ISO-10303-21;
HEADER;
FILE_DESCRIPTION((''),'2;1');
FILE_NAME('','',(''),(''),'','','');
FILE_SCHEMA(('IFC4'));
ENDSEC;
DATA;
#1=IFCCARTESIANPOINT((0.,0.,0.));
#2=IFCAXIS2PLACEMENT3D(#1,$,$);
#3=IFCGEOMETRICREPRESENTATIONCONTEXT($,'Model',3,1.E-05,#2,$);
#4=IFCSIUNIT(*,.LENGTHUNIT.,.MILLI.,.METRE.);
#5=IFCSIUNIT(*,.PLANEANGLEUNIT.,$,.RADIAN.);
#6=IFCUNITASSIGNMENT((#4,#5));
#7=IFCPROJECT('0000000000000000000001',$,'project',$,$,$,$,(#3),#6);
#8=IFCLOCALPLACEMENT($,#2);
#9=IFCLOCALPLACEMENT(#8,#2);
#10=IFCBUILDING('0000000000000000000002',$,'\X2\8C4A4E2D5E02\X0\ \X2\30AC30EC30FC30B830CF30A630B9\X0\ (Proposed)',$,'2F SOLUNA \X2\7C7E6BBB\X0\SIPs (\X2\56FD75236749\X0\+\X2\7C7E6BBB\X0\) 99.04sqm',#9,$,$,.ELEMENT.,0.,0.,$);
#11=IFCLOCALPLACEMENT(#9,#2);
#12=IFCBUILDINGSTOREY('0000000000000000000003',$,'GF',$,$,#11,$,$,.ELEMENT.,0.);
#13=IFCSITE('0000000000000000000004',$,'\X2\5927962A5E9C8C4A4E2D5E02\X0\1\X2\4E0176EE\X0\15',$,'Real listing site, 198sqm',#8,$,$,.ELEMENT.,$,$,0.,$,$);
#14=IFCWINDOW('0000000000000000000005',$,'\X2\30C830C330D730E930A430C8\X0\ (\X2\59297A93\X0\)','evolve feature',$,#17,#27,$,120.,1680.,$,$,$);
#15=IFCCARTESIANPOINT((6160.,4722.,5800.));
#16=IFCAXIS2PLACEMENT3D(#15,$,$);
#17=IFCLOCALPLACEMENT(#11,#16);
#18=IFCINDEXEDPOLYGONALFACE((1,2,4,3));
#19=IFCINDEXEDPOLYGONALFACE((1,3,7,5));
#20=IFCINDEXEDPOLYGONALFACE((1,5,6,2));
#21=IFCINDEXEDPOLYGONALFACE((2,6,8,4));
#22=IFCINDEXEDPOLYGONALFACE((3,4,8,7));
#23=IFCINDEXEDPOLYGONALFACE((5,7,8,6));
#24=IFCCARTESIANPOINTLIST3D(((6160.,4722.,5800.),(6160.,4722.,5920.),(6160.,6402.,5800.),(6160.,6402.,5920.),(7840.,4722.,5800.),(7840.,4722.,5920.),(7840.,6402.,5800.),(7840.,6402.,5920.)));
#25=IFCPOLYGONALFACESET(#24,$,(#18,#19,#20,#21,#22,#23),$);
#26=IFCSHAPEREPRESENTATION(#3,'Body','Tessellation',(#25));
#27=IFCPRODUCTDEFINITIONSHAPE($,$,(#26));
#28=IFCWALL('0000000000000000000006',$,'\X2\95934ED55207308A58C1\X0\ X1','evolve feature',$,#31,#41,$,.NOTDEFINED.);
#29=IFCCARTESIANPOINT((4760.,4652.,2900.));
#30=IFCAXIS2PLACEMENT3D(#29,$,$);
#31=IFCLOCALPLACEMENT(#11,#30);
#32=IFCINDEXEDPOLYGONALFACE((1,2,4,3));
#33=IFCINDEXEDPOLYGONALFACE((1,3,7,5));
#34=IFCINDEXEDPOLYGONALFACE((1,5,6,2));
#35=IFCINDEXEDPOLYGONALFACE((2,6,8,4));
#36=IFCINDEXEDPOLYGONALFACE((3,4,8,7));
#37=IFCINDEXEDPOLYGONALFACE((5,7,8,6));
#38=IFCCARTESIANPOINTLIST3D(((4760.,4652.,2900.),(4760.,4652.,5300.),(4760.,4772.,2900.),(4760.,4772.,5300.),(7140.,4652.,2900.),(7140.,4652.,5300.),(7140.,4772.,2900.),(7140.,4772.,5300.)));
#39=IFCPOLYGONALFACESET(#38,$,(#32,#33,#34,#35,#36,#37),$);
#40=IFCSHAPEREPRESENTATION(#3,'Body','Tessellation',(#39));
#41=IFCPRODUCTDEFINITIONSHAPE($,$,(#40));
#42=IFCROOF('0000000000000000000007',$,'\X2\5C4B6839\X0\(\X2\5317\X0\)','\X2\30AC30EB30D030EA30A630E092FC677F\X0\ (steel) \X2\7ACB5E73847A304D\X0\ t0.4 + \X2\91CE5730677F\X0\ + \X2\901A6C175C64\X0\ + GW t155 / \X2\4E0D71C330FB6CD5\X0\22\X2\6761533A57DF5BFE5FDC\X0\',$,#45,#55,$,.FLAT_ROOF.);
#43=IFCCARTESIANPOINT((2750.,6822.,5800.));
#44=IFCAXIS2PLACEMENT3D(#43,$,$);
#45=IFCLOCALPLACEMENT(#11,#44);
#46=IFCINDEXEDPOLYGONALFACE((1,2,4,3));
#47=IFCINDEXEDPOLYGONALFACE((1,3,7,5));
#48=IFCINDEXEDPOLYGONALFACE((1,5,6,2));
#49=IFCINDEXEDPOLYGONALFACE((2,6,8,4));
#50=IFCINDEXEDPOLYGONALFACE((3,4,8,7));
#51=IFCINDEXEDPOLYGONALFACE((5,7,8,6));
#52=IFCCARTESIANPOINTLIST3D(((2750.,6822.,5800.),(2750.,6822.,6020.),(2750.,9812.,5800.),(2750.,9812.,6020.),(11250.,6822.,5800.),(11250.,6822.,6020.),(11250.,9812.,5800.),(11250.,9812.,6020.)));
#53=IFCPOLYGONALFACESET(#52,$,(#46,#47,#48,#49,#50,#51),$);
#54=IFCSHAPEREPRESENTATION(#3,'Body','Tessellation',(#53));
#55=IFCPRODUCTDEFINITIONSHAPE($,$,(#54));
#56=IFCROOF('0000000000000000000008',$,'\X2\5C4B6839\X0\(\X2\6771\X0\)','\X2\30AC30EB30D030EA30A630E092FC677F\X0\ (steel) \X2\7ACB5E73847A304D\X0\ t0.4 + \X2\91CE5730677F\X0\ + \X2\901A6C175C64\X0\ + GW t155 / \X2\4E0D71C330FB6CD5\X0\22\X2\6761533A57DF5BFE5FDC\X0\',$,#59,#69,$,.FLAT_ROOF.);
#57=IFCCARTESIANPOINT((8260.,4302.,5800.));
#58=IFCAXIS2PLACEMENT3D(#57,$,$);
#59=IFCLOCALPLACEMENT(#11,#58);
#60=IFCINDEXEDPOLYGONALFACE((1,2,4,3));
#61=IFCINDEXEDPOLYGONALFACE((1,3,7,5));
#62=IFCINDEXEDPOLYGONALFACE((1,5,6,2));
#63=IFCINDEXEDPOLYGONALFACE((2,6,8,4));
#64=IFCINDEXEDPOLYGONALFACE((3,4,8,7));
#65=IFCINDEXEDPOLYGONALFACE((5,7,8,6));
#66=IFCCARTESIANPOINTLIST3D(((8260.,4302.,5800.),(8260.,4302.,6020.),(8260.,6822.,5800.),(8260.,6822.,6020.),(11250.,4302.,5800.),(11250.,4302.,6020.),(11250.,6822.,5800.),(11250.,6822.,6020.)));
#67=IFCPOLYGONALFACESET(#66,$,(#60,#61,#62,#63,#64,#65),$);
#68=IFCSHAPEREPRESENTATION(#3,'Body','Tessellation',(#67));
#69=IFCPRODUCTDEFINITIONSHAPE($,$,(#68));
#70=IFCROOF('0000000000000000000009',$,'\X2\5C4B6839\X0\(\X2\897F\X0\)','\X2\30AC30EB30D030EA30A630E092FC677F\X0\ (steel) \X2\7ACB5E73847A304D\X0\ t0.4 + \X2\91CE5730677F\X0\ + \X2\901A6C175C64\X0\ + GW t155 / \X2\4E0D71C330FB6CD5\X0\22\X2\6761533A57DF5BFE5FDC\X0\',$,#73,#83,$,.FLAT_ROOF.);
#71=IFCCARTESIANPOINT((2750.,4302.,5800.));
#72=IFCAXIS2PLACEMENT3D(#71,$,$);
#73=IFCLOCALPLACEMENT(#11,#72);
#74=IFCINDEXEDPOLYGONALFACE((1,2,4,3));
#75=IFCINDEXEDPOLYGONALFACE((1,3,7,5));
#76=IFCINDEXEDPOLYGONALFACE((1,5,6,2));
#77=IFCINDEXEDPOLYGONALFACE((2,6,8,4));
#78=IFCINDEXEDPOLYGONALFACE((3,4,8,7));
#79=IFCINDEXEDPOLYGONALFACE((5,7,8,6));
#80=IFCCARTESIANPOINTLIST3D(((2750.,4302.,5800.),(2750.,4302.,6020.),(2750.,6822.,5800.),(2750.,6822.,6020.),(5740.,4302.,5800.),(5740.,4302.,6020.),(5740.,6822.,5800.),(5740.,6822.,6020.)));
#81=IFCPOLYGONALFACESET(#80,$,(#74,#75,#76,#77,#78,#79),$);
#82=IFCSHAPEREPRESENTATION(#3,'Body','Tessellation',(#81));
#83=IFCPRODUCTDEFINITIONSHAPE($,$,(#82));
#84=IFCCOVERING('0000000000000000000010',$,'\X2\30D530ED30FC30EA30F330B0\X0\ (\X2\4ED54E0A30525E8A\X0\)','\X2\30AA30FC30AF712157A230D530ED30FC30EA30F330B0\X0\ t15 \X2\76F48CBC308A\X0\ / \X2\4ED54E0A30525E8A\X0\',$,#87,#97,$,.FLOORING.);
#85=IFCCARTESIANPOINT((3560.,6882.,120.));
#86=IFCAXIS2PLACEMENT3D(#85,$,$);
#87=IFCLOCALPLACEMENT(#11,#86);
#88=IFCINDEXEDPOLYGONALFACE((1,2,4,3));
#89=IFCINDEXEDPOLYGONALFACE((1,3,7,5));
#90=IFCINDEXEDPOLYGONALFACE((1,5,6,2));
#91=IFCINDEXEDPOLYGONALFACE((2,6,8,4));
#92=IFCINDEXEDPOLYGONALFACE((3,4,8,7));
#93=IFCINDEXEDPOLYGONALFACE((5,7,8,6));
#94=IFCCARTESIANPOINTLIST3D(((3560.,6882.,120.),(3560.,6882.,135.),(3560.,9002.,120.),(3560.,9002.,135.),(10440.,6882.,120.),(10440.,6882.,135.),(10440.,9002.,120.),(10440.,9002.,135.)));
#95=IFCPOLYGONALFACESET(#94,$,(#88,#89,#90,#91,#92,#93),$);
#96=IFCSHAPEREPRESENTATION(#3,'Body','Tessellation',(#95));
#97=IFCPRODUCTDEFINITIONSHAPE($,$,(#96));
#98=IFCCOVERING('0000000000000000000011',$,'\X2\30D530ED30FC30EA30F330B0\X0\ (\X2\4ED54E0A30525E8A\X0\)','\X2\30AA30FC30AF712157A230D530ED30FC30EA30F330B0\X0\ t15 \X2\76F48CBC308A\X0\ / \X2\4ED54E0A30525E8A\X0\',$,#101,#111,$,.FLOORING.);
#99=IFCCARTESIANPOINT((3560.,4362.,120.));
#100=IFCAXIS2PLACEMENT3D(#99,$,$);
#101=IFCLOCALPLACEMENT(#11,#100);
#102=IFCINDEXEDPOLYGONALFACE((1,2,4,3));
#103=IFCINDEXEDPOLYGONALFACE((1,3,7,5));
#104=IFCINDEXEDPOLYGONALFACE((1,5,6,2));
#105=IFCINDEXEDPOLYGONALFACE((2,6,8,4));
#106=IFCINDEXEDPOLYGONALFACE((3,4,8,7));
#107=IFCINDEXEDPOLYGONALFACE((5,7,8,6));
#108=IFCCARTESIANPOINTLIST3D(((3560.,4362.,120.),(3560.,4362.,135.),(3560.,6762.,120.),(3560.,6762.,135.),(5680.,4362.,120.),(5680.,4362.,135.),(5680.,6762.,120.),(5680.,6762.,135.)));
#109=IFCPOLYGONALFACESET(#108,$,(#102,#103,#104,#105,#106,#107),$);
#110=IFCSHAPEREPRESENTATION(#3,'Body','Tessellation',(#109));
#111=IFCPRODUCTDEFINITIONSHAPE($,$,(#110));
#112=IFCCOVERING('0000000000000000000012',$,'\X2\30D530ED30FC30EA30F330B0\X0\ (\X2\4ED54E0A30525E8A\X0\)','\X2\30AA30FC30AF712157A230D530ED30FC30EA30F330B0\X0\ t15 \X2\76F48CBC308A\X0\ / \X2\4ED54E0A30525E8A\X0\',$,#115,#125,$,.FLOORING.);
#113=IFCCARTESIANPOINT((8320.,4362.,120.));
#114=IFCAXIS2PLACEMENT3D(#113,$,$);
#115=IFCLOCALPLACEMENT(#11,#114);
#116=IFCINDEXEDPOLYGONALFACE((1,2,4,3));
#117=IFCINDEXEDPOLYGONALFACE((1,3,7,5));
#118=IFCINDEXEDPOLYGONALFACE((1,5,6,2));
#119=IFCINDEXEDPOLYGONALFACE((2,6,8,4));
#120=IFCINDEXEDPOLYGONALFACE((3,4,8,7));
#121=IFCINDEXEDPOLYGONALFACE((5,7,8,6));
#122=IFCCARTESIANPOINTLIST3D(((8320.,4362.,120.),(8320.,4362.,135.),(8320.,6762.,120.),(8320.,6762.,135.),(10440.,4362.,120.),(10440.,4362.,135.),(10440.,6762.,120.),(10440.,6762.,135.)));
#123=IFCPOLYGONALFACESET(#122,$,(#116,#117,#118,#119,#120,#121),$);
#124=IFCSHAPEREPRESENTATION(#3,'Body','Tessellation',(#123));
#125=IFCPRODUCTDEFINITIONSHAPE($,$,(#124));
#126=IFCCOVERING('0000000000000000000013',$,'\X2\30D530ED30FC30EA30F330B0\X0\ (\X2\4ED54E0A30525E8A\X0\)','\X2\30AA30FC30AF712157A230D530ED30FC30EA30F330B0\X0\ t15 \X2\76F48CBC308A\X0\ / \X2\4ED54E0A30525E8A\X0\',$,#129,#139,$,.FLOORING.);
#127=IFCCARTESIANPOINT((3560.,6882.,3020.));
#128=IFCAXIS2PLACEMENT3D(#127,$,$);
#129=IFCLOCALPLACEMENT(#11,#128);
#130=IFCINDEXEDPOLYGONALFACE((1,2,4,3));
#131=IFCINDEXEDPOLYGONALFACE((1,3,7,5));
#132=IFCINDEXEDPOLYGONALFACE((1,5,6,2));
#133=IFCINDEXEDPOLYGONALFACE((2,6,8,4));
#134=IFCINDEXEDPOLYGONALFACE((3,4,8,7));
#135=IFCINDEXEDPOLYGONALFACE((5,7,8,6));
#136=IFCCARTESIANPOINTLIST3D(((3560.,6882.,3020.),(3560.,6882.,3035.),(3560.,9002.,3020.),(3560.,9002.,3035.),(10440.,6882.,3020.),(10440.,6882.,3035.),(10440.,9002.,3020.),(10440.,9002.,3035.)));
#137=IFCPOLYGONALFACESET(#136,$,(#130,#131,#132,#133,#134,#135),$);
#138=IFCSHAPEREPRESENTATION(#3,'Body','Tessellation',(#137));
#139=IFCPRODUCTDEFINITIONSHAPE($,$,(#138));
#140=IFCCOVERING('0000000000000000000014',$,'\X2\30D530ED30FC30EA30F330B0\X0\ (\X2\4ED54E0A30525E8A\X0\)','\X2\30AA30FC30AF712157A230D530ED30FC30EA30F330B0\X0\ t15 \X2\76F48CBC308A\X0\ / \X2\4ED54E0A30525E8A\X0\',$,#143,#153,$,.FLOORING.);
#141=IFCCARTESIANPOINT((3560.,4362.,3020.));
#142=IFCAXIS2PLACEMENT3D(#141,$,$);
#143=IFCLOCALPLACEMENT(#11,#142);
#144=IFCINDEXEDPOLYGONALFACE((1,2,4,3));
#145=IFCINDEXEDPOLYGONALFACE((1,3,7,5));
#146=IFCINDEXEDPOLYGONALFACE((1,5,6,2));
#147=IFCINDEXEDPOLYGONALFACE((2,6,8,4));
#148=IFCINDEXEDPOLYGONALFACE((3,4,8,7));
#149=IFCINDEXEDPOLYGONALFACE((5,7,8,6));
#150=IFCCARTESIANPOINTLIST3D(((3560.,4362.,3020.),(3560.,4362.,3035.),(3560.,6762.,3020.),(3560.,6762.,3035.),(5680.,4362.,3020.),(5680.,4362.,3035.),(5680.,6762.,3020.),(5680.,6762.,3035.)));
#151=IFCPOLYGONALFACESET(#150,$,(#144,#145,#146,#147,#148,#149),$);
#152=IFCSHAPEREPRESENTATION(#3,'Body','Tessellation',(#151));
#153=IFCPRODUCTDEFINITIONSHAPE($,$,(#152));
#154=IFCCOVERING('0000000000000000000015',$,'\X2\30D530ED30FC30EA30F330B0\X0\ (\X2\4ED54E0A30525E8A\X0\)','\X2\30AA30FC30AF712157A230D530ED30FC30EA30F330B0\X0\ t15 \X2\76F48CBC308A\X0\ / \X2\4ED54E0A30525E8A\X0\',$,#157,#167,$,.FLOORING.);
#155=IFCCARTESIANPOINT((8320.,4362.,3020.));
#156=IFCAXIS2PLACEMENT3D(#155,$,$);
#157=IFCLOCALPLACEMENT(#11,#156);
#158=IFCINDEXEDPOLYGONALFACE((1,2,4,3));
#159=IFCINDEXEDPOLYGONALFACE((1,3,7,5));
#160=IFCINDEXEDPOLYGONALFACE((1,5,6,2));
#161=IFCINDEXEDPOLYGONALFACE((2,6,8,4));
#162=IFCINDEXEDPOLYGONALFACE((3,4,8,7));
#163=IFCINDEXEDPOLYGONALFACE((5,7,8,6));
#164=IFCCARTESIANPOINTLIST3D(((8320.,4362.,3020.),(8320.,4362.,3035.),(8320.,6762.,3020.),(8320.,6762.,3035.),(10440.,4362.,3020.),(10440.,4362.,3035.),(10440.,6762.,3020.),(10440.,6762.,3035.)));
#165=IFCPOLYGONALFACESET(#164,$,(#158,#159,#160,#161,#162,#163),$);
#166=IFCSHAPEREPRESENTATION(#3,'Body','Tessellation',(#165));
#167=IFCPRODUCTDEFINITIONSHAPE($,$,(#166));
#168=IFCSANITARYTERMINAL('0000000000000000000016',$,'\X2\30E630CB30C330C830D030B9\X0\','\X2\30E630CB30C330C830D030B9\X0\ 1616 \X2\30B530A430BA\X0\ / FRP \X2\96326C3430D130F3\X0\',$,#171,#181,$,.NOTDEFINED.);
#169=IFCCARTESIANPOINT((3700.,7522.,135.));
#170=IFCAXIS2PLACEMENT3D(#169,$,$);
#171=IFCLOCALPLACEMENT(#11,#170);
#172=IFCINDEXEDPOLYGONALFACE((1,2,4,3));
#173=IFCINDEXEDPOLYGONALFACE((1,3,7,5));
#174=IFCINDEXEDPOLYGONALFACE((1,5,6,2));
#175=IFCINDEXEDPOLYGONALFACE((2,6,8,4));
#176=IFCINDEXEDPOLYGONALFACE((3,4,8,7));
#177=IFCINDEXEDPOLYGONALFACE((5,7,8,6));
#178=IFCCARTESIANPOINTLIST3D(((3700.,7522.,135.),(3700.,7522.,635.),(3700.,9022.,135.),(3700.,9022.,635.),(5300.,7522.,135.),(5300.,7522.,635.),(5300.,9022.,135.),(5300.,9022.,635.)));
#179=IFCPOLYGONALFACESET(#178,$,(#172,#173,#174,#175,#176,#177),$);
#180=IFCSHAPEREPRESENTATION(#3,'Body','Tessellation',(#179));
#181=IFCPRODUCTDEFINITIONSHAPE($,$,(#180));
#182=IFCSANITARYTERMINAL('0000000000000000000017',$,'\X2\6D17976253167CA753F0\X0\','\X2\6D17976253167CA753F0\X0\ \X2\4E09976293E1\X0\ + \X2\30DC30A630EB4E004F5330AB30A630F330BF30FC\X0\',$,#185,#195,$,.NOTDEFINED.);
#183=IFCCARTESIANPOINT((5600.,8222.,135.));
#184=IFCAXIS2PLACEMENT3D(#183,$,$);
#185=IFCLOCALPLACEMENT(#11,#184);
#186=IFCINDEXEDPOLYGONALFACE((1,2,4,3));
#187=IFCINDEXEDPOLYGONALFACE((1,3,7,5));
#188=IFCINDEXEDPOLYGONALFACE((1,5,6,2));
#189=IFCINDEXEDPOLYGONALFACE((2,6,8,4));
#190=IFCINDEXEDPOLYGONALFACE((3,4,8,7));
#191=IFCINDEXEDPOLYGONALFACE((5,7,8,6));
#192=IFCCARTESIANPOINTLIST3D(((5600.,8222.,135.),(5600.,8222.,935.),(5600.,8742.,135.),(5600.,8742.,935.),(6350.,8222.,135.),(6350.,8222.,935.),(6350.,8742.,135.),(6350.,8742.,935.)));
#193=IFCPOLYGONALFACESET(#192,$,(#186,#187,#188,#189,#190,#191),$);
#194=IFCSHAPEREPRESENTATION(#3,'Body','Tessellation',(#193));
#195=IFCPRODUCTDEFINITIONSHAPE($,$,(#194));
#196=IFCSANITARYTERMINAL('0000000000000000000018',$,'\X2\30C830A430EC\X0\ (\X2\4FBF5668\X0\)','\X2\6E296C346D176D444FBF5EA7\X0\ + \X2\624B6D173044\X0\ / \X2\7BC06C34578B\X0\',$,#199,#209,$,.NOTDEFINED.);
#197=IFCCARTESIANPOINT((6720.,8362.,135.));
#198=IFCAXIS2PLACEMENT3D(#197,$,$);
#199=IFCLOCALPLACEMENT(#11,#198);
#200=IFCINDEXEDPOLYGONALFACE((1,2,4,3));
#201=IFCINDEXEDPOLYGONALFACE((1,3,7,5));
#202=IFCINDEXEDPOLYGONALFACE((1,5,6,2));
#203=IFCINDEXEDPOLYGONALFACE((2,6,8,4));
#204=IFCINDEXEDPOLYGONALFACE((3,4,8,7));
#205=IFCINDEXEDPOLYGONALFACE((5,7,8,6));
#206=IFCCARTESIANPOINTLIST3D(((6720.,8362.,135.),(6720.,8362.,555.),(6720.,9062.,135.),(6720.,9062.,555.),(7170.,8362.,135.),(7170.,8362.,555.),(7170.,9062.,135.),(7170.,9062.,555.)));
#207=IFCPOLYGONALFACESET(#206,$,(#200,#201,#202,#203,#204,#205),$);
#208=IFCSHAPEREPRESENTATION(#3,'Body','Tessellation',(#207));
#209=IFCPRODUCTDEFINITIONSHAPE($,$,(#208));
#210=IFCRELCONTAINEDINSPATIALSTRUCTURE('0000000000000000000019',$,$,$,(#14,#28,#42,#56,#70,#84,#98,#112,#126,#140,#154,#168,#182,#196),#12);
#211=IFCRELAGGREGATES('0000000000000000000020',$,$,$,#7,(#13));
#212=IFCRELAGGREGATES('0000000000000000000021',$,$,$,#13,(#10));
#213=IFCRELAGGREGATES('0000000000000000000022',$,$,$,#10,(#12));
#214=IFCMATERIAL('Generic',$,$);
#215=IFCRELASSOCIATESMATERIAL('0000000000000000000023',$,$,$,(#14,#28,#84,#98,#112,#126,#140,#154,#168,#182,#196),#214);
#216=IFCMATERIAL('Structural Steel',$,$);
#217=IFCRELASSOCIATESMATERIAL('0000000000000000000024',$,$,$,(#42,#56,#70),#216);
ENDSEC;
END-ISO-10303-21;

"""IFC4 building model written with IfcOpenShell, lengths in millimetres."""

from ifc_helpers import new_model, si_unit, frame, frame_2d, origin, place, context, project, spatial, rectangle, extrude, material, element, save


model = new_model("IFC4")

# Units and contexts
model_context = context("Model", 3, precision=1e-05, world=origin())
ifc_project = project(units=[si_unit("LENGTHUNIT", "METRE", prefix="MILLI"), si_unit("PLANEANGLEUNIT", "RADIAN")], contexts=[model_context])

# Site, building, storey
site_placement = place(None, origin())
site = spatial("IfcSite", under=ifc_project, at=site_placement, Name="大阪府豊中市1丁目15", ObjectType="Real listing site, 198sqm", CompositionType="ELEMENT", RefElevation=0.0)
building_placement = place(site_placement, origin())
building = spatial("IfcBuilding", under=site, at=building_placement, Name="豊中市 ガレージハウス (Proposed)", ObjectType="2F SOLUNA 籾殻SIPs (国産杉+籾殻) 99.04sqm", CompositionType="ELEMENT", ElevationOfRefHeight=0.0, ElevationOfTerrain=0.0)
storey_placement = place(building_placement, origin())
storey = spatial("IfcBuildingStorey", under=building, at=storey_placement, Name="GF", CompositionType="ELEMENT", Elevation=0.0)

# Window
ifc_material_1 = material(Name="Generic")
window_1_placement = place(storey_placement, frame((6160.0, 4722.0, 5800.0)))
element("IfcWindow", 1, at=window_1_placement, inside=storey, material=ifc_material_1, Name="トップライト (天窓)", Description="evolve feature", OverallHeight=120.0, OverallWidth=1680.0, context=model_context, shape_type="SweptSolid", body=[
    extrude(rectangle(XDim=1680.0, YDim=1680.0, at=frame_2d((840.0, 840.0))), frame((6160.0, 4722.0, 5800.0)), (0.0, 0.0, 1.0), 120.0),
])

# Wall
wall_1_placement = place(storey_placement, frame((4760.0, 4652.0, 2900.0)))
element("IfcWall", 2, at=wall_1_placement, inside=storey, material=ifc_material_1, Name="間仕切り壁 X1", Description="evolve feature", PredefinedType="NOTDEFINED", context=model_context, shape_type="SweptSolid", body=[
    extrude(rectangle(XDim=2380.0, YDim=120.0, at=frame_2d((1190.0, 60.0))), frame((4760.0, 4652.0, 2900.0)), (0.0, 0.0, 1.0), 2400.0),
])

# Roofs
ifc_material_2 = material(Name="Structural Steel")
roof_1_placement = place(storey_placement, frame((2750.0, 6822.0, 5800.0)))
element("IfcRoof", 3, at=roof_1_placement, inside=storey, material=ifc_material_2, Name="屋根(北)", Description="ガルバリウム鋼板 (steel) 立平葺き t0.4 + 野地板 + 通気層 + GW t155 / 不燃・法22条区域対応", PredefinedType="FLAT_ROOF", context=model_context, shape_type="SweptSolid", body=[
    extrude(rectangle(XDim=8500.0, YDim=2990.0, at=frame_2d((4250.0, 1495.0))), frame((2750.0, 6822.0, 5800.0)), (0.0, 0.0, 1.0), 220.0),
])
roof_2_placement = place(storey_placement, frame((8260.0, 4302.0, 5800.0)))
element("IfcRoof", 4, at=roof_2_placement, inside=storey, material=ifc_material_2, Name="屋根(東)", Description="ガルバリウム鋼板 (steel) 立平葺き t0.4 + 野地板 + 通気層 + GW t155 / 不燃・法22条区域対応", PredefinedType="FLAT_ROOF", context=model_context, shape_type="SweptSolid", body=[
    extrude(rectangle(XDim=2990.0, YDim=2520.0, at=frame_2d((1495.0, 1260.0))), frame((8260.0, 4302.0, 5800.0)), (0.0, 0.0, 1.0), 220.0),
])
roof_3_placement = place(storey_placement, frame((2750.0, 4302.0, 5800.0)))
element("IfcRoof", 5, at=roof_3_placement, inside=storey, material=ifc_material_2, Name="屋根(西)", Description="ガルバリウム鋼板 (steel) 立平葺き t0.4 + 野地板 + 通気層 + GW t155 / 不燃・法22条区域対応", PredefinedType="FLAT_ROOF", context=model_context, shape_type="SweptSolid", body=[
    extrude(rectangle(XDim=2990.0, YDim=2520.0, at=frame_2d((1495.0, 1260.0))), frame((2750.0, 4302.0, 5800.0)), (0.0, 0.0, 1.0), 220.0),
])

# Coverings
covering_1_placement = place(storey_placement, frame((3560.0, 6882.0, 120.0)))
element("IfcCovering", 6, at=covering_1_placement, inside=storey, material=ifc_material_1, Name="フローリング (仕上げ床)", Description="オーク無垢フローリング t15 直貼り / 仕上げ床", PredefinedType="FLOORING", context=model_context, shape_type="SweptSolid", body=[
    extrude(rectangle(XDim=6880.0, YDim=2120.0, at=frame_2d((3440.0, 1060.0))), frame((3560.0, 6882.0, 120.0)), (0.0, 0.0, 1.0), 15.0),
])
covering_2_placement = place(storey_placement, frame((3560.0, 4362.0, 120.0)))
element("IfcCovering", 7, at=covering_2_placement, inside=storey, material=ifc_material_1, Name="フローリング (仕上げ床)", Description="オーク無垢フローリング t15 直貼り / 仕上げ床", PredefinedType="FLOORING", context=model_context, shape_type="SweptSolid", body=[
    extrude(rectangle(XDim=2120.0, YDim=2400.0, at=frame_2d((1060.0, 1200.0))), frame((3560.0, 4362.0, 120.0)), (0.0, 0.0, 1.0), 15.0),
])
covering_3_placement = place(storey_placement, frame((8320.0, 4362.0, 120.0)))
element("IfcCovering", 8, at=covering_3_placement, inside=storey, material=ifc_material_1, Name="フローリング (仕上げ床)", Description="オーク無垢フローリング t15 直貼り / 仕上げ床", PredefinedType="FLOORING", context=model_context, shape_type="SweptSolid", body=[
    extrude(rectangle(XDim=2120.0, YDim=2400.0, at=frame_2d((1060.0, 1200.0))), frame((8320.0, 4362.0, 120.0)), (0.0, 0.0, 1.0), 15.0),
])
covering_4_placement = place(storey_placement, frame((3560.0, 6882.0, 3020.0)))
element("IfcCovering", 9, at=covering_4_placement, inside=storey, material=ifc_material_1, Name="フローリング (仕上げ床)", Description="オーク無垢フローリング t15 直貼り / 仕上げ床", PredefinedType="FLOORING", context=model_context, shape_type="SweptSolid", body=[
    extrude(rectangle(XDim=6880.0, YDim=2120.0, at=frame_2d((3440.0, 1060.0))), frame((3560.0, 6882.0, 3020.0)), (0.0, 0.0, 1.0), 15.0),
])
covering_5_placement = place(storey_placement, frame((3560.0, 4362.0, 3020.0)))
element("IfcCovering", 10, at=covering_5_placement, inside=storey, material=ifc_material_1, Name="フローリング (仕上げ床)", Description="オーク無垢フローリング t15 直貼り / 仕上げ床", PredefinedType="FLOORING", context=model_context, shape_type="SweptSolid", body=[
    extrude(rectangle(XDim=2120.0, YDim=2400.0, at=frame_2d((1060.0, 1200.0))), frame((3560.0, 4362.0, 3020.0)), (0.0, 0.0, 1.0), 15.0),
])
covering_6_placement = place(storey_placement, frame((8320.0, 4362.0, 3020.0)))
element("IfcCovering", 11, at=covering_6_placement, inside=storey, material=ifc_material_1, Name="フローリング (仕上げ床)", Description="オーク無垢フローリング t15 直貼り / 仕上げ床", PredefinedType="FLOORING", context=model_context, shape_type="SweptSolid", body=[
    extrude(rectangle(XDim=2120.0, YDim=2400.0, at=frame_2d((1060.0, 1200.0))), frame((8320.0, 4362.0, 3020.0)), (0.0, 0.0, 1.0), 15.0),
])

# Sanitary terminals
sanitary_terminal_1_placement = place(storey_placement, frame((3700.0, 7522.0, 135.0)))
element("IfcSanitaryTerminal", 12, at=sanitary_terminal_1_placement, inside=storey, material=ifc_material_1, Name="ユニットバス", Description="ユニットバス 1616 サイズ / FRP 防水パン", PredefinedType="NOTDEFINED", context=model_context, shape_type="SweptSolid", body=[
    extrude(rectangle(XDim=1600.0, YDim=1500.0, at=frame_2d((800.0, 750.0))), frame((3700.0, 7522.0, 135.0)), (0.0, 0.0, 1.0), 500.0),
])
sanitary_terminal_2_placement = place(storey_placement, frame((5600.0, 8222.0, 135.0)))
element("IfcSanitaryTerminal", 13, at=sanitary_terminal_2_placement, inside=storey, material=ifc_material_1, Name="洗面化粧台", Description="洗面化粧台 三面鏡 + ボウル一体カウンター", PredefinedType="NOTDEFINED", context=model_context, shape_type="SweptSolid", body=[
    extrude(rectangle(XDim=750.0, YDim=520.0, at=frame_2d((375.0, 260.0))), frame((5600.0, 8222.0, 135.0)), (0.0, 0.0, 1.0), 800.0),
])
sanitary_terminal_3_placement = place(storey_placement, frame((6720.0, 8362.0, 135.0)))
element("IfcSanitaryTerminal", 14, at=sanitary_terminal_3_placement, inside=storey, material=ifc_material_1, Name="トイレ (便器)", Description="温水洗浄便座 + 手洗い / 節水型", PredefinedType="NOTDEFINED", context=model_context, shape_type="SweptSolid", body=[
    extrude(rectangle(XDim=450.0, YDim=700.0, at=frame_2d((225.0, 350.0))), frame((6720.0, 8362.0, 135.0)), (0.0, 0.0, 1.0), 420.0),
])

save(model, "model.ifc")
